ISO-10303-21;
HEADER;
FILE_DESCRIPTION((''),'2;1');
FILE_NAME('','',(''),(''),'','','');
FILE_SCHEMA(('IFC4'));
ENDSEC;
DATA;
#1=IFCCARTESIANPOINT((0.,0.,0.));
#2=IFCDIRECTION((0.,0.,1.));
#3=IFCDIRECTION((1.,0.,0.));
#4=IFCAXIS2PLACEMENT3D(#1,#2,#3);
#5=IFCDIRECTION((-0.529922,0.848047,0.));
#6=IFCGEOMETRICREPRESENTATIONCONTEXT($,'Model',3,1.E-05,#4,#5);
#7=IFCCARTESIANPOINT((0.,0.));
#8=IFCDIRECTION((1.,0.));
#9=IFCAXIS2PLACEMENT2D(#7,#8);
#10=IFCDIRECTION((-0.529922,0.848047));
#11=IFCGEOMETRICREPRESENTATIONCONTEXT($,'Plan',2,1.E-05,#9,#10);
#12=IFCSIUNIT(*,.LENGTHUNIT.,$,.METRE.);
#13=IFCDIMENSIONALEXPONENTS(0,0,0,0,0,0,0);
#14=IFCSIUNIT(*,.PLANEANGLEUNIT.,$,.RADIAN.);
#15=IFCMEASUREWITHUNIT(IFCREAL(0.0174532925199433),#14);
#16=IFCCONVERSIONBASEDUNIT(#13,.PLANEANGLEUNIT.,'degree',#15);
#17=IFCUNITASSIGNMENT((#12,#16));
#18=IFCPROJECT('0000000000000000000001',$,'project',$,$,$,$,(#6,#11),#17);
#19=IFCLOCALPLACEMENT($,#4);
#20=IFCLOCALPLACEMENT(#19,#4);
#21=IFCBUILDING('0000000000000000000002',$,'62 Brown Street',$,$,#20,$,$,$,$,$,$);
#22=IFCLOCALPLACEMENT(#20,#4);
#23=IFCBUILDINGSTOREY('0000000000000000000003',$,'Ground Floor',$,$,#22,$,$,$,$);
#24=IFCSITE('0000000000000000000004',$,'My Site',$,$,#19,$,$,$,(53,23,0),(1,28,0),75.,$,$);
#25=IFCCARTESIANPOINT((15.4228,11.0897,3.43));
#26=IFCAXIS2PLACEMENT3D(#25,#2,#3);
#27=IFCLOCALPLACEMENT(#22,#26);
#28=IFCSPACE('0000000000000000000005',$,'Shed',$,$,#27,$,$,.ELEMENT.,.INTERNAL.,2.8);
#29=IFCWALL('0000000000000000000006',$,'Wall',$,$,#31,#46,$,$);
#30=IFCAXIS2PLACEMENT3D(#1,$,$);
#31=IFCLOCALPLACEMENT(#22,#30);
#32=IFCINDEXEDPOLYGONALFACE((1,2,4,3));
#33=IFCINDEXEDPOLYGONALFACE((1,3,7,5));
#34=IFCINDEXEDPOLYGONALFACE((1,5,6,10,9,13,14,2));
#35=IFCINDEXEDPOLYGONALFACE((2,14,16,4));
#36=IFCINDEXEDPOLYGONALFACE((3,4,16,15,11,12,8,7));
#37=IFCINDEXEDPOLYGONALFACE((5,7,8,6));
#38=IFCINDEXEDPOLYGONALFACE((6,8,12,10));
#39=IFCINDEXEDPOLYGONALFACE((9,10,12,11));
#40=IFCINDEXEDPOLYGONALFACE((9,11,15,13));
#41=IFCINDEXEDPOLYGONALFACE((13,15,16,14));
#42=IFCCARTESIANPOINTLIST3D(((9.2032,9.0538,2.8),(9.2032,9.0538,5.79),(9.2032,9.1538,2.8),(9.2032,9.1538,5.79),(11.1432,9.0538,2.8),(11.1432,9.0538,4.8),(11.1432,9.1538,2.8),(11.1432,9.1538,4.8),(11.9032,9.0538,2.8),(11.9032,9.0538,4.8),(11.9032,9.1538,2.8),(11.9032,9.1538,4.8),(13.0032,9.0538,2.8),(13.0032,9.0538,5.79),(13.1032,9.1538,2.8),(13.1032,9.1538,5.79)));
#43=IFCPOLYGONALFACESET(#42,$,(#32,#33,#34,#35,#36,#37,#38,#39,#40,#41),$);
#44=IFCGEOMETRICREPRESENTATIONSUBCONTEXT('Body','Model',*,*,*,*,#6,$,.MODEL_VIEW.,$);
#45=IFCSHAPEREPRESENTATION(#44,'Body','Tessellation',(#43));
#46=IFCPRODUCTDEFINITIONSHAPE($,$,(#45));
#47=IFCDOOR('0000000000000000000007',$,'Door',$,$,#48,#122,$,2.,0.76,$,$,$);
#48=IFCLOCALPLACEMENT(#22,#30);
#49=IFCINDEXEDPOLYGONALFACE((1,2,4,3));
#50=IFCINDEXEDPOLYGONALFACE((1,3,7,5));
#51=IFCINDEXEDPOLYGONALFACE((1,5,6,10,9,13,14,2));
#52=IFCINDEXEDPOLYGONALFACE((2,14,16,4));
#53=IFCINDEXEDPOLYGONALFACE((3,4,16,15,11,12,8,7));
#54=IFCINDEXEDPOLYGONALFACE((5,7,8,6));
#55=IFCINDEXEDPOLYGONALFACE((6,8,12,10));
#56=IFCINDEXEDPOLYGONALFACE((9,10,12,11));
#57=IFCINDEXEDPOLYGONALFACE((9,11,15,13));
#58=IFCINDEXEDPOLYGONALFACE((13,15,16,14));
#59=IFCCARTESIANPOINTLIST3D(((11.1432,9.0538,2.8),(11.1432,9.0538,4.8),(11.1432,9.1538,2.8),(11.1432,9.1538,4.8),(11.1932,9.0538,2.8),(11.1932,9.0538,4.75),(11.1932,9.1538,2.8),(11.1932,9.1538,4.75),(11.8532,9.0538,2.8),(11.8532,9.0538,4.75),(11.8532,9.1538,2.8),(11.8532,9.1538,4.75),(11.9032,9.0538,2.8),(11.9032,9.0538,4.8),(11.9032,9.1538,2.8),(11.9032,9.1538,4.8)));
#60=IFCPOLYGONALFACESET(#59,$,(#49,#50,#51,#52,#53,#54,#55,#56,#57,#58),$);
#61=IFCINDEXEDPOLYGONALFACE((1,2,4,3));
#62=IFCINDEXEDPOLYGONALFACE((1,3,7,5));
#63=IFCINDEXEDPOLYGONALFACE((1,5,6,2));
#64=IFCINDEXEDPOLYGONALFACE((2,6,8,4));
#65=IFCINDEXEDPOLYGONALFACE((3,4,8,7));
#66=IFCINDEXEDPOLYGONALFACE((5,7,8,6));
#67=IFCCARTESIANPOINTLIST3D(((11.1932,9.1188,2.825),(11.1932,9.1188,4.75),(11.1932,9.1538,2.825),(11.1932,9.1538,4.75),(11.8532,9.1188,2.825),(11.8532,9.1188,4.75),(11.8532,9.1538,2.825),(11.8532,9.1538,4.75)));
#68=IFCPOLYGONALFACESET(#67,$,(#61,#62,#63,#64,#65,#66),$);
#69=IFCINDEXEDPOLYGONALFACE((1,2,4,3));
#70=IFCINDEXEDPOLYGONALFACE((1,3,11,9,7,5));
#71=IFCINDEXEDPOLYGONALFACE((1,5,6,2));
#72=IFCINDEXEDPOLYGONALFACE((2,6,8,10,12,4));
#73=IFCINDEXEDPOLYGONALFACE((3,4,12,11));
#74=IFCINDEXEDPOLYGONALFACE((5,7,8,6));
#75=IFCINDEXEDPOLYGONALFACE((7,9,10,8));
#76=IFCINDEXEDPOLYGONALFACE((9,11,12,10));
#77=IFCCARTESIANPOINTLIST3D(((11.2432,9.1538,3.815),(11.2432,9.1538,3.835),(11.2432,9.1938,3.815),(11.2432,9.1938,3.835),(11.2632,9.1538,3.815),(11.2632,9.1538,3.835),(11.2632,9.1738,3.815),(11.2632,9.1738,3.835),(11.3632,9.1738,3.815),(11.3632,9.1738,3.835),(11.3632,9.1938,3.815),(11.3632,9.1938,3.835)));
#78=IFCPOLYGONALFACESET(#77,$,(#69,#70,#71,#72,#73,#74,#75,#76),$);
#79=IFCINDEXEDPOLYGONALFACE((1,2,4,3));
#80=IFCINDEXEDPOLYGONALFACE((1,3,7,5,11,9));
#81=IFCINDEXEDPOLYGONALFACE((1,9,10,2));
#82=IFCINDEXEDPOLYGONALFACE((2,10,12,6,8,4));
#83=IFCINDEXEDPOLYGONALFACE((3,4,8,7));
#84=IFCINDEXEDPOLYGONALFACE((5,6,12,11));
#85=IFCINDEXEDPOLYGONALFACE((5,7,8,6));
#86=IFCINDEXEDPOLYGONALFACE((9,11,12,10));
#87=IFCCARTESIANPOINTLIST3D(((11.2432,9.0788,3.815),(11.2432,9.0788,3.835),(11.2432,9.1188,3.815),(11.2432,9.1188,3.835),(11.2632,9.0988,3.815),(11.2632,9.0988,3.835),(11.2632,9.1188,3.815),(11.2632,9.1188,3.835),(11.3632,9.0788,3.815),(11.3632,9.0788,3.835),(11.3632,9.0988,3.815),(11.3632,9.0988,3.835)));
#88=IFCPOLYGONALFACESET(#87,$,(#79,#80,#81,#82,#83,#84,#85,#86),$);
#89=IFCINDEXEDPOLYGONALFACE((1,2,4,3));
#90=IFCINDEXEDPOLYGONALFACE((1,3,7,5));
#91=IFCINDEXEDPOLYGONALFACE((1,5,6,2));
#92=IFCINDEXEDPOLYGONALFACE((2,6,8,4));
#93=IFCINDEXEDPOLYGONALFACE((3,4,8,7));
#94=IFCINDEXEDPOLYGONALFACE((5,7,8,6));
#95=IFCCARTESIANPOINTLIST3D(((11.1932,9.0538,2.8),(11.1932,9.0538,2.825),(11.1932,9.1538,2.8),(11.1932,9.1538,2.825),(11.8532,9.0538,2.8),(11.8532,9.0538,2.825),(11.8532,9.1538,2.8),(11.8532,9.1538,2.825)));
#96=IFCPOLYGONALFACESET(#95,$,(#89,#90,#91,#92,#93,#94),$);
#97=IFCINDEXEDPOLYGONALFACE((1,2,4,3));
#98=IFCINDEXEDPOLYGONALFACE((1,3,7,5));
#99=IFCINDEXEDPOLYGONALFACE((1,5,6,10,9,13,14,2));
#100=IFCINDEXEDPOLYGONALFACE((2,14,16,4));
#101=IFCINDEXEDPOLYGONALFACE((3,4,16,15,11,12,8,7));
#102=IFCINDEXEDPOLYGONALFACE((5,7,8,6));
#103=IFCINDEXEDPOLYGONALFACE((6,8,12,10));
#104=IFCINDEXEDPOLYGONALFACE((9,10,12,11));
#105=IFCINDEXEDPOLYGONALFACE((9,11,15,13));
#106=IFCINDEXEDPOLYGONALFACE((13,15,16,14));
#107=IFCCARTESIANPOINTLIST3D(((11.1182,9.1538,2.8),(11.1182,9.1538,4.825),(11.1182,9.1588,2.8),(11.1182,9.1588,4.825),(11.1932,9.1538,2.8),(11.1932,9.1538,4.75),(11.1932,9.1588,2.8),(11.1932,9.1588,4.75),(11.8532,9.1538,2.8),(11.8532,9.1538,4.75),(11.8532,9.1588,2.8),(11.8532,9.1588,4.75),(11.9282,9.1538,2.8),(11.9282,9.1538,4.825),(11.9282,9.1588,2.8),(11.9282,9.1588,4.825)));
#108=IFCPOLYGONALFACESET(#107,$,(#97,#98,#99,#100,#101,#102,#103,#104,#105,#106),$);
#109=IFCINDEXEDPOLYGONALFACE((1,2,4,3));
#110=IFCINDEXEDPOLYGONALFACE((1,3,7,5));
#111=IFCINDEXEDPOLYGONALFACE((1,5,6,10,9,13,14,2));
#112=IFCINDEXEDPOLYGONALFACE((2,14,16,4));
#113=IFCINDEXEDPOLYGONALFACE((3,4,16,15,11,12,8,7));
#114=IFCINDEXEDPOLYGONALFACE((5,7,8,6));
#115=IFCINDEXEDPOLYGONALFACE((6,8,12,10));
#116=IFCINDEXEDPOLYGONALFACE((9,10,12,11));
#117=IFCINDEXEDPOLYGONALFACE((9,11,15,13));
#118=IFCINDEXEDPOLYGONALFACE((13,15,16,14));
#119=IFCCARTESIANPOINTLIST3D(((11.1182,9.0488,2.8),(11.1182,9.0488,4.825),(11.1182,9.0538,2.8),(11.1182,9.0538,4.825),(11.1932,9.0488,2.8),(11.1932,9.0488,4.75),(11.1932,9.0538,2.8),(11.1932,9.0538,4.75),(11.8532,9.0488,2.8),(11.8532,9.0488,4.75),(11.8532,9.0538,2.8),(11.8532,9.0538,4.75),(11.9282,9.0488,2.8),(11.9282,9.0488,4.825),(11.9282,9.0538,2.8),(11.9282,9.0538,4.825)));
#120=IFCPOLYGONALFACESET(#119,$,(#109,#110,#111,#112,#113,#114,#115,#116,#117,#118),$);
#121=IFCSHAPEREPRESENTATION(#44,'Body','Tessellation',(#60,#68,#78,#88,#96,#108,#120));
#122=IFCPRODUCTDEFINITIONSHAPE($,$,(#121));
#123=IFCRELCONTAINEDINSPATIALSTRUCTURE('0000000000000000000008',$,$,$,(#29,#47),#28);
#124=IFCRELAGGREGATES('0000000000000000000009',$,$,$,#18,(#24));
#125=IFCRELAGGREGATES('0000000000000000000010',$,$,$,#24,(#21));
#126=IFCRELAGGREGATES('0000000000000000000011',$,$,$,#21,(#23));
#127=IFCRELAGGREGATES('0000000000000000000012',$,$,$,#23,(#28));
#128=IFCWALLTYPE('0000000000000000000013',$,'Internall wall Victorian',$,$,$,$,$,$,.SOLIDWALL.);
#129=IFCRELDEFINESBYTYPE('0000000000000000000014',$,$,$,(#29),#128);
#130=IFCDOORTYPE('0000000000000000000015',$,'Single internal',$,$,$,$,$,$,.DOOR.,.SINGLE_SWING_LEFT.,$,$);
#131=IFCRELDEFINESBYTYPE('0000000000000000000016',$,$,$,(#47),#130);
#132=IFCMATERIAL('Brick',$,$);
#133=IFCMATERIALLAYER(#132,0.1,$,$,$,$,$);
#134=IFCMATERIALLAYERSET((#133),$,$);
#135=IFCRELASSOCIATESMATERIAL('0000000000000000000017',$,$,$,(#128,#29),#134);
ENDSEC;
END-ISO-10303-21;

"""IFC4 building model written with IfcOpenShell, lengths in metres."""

from ifc_helpers import new_model, entity, si_unit, converted_unit, direction, frame, origin_with_axes, origin_2d_with_axis, place, context, subcontext, project, spatial, line, indexed_curve, outline, extrude, clip, halfspace, shape, source, transform, mapped, material, layer, layer_set, layer_usage, type_object, type_shapes, element, fill, save


model = new_model("IFC4")

# Units and contexts
model_context = context("Model", 3, precision=1e-05, world=origin_with_axes(), true_north=direction((-0.529922, 0.848047, 0.0)))
plan_context = context("Plan", 2, precision=1e-05, world=origin_2d_with_axis(), true_north=direction((-0.529922, 0.848047)))
body_context_1 = subcontext(model_context, "Body", "Model", "MODEL_VIEW")
body_context_2 = subcontext(plan_context, "Body", "Plan", "PLAN_VIEW")
ifc_project = project(units=[si_unit("LENGTHUNIT", "METRE"), converted_unit("PLANEANGLEUNIT", "degree", entity("IfcReal", 0.0174532925199433), si_unit("PLANEANGLEUNIT", "RADIAN"), dimensions=[0, 0, 0, 0, 0, 0, 0])], contexts=[model_context, plan_context])

# Site, building, storey
site_placement = place(None, origin_with_axes())
site = spatial("IfcSite", under=ifc_project, at=site_placement, Name="My Site", RefLatitude=(53, 23, 0), RefLongitude=(1, 28, 0), RefElevation=75.0)
building_placement = place(site_placement, origin_with_axes())
building = spatial("IfcBuilding", under=site, at=building_placement, Name="62 Brown Street")
storey_placement = place(building_placement, origin_with_axes())
storey = spatial("IfcBuildingStorey", under=building, at=storey_placement, Name="Ground Floor")

# Shared definitions
space_placement = place(storey_placement, frame((15.4228, 11.0897, 3.43), z_axis=(0.0, 0.0, 1.0), x_axis=(1.0, 0.0, 0.0)))
space = spatial("IfcSpace", under=storey, at=space_placement, Name="Shed", CompositionType="ELEMENT", PredefinedType="INTERNAL", ElevationWithFlooring=2.8)

# Shared definitions
ifc_material_1 = material(Name="Brick")
ifc_layer_1 = layer(ifc_material_1, 0.1)
ifc_layer_set_1 = layer_set([ifc_layer_1])
wall_type = type_object("IfcWallType", Name="Internall wall Victorian", PredefinedType="SOLIDWALL", material=ifc_layer_set_1)

# Wall, opening, door
ifc_layer_usage_1 = layer_usage(ifc_layer_set_1, "AXIS2", "POSITIVE", 0.0)
wall_1_placement = place(None, frame((13.1032, 9.1538, 2.8), z_axis=(0.0, 0.0, 1.0), x_axis=(-1.0, 0.0, 0.0)))
wall_1 = element("IfcWall", 1, at=wall_1_placement, inside=space, type_object=wall_type, material=ifc_layer_usage_1, Name="Wall", context=body_context_1, shape_type="Clipping", body=[
    clip(extrude(outline(indexed_curve([(0.0, 0.0), (0.0, 0.1), (3.9, 0.1), (3.9, 0.0), (0.0, 0.0)], self_intersect=False)), origin_with_axes(), (0.0, 0.0, 1.0), 2.99), halfspace(frame((0.0, 0.0, -2.8), z_axis=(-0.707104, 0.70711, 0.0), x_axis=(0.70711, 0.707104, 0.0)), False)),
])
shared_shape_1 = source(origin_with_axes(), body_context_1, "Body", "SweptSolid", [
    extrude(outline(indexed_curve([(0.0, 0.0), (0.76, 0.0), (0.76, 2.0), (0.0, 2.0)], segments=[line(1, 2, 3, 4, 1)])), frame((0.0, -0.6, 0.0), z_axis=(0.0, -1.0, 0.0), x_axis=(1.0, 0.0, 0.0)), (0.0, 0.0, -1.0), 1.2),
])
opening_placement = place(wall_1_placement, frame((1.2, 0.0, 0.0), z_axis=(0.0, 0.0, 1.0), x_axis=(1.0, 0.0, 0.0)))
opening = element("IfcOpeningElement", 2, at=opening_placement, cuts=wall_1, PredefinedType="OPENING", context=body_context_1, shape_type="MappedRepresentation", body=[
    mapped(shared_shape_1, transform((0.0, 0.0, 0.0), x_axis=(1.0, 0.0, 0.0), y_axis=(0.0, 1.0, 0.0), z_axis=(0.0, 0.0, 1.0), scale=1.0)),
])
door_type = type_object("IfcDoorType", Name="Single internal", OperationType="SINGLE_SWING_LEFT", PredefinedType="DOOR")
shared_shape_2 = source(origin_with_axes(), body_context_1, "Body", "SweptSolid", [
    extrude(outline(indexed_curve([(0.0, 0.0), (0.0, 2.0), (0.76, 2.0), (0.76, 0.0), (0.71, 0.0), (0.71, 1.95), (0.05, 1.95), (0.05, 0.0)], segments=[line(1, 2, 3, 4, 5, 6, 7, 8, 1)])), frame((0.0, 0.0, 0.0), z_axis=(0.0, -1.0, 0.0), x_axis=(1.0, 0.0, 0.0)), (0.0, 0.0, -1.0), 0.1),
    extrude(outline(indexed_curve([(0.0, 0.0), (0.66, 0.0), (0.66, 0.035), (0.0, 0.035)], segments=[line(1, 2, 3, 4, 1)])), frame((0.05, 0.0, 0.025), z_axis=(0.0, 0.0, 1.0), x_axis=(1.0, 0.0, 0.0)), (0.0, 0.0, 1.0), 1.925),
    extrude(outline(indexed_curve([(0.0, 0.0), (0.0, -0.04), (-0.12, -0.04), (-0.12, -0.02), (-0.02, -0.02), (-0.02, 0.0)], segments=[line(1, 2, 3, 4, 5, 6, 1)])), frame((0.66, 0.0, 1.015), z_axis=(0.0, 0.0, 1.0), x_axis=(1.0, 0.0, 0.0)), (0.0, 0.0, 1.0), 0.02),
    extrude(outline(indexed_curve([(0.0, 0.0), (0.0, 0.04), (-0.12, 0.04), (-0.12, 0.02), (-0.02, 0.02), (-0.02, 0.0)], segments=[line(1, 2, 3, 4, 5, 6, 1)])), frame((0.66, 0.035, 1.015), z_axis=(0.0, 0.0, 1.0), x_axis=(1.0, 0.0, 0.0)), (0.0, 0.0, 1.0), 0.02),
    extrude(outline(indexed_curve([(0.0, 0.0), (0.66, 0.0), (0.66, 0.1), (0.0, 0.1)], segments=[line(1, 2, 3, 4, 1)])), frame((0.05, 0.0, 0.0), z_axis=(0.0, 0.0, 1.0), x_axis=(1.0, 0.0, 0.0)), (0.0, 0.0, 1.0), 0.025),
    extrude(outline(indexed_curve([(0.0, 0.0), (0.0, 2.025), (0.81, 2.025), (0.81, 0.0), (0.735, 0.0), (0.735, 1.95), (0.075, 1.95), (0.075, 0.0)], segments=[line(1, 2, 3, 4, 5, 6, 7, 8, 1)])), frame((-0.025, -0.005, 0.0), z_axis=(0.0, -1.0, 0.0), x_axis=(1.0, 0.0, 0.0)), (0.0, 0.0, -1.0), 0.005),
    extrude(outline(indexed_curve([(0.0, 0.0), (0.0, 2.025), (0.81, 2.025), (0.81, 0.0), (0.735, 0.0), (0.735, 1.95), (0.075, 1.95), (0.075, 0.0)], segments=[line(1, 2, 3, 4, 5, 6, 7, 8, 1)])), frame((-0.025, 0.1, 0.0), z_axis=(0.0, -1.0, 0.0), x_axis=(1.0, 0.0, 0.0)), (0.0, 0.0, -1.0), 0.005),
])
shared_shape_3 = source(origin_with_axes(), body_context_2, "Body", "Curve2D", [
    entity("IfcIndexedPolyCurve", entity("IfcCartesianPointList2D", [[0.0, 0.0], [0.05, 0.0], [0.05, 0.1], [0.0, 0.1]]), [entity("IfcLineIndex", [1, 2, 3, 4, 1])]),
    entity("IfcIndexedPolyCurve", entity("IfcCartesianPointList2D", [[0.76, 0.0], [0.71, 0.0], [0.71, 0.1], [0.76, 0.1]]), [entity("IfcLineIndex", [1, 2, 3, 4, 1])]),
    entity("IfcTrimmedCurve", entity("IfcEllipse", entity("IfcAxis2Placement2D", entity("IfcCartesianPoint", [0.085, 0.1]), entity("IfcDirection", [1.0, 0.0])), 0.625, 0.66), [entity("IfcCartesianPoint", [0.71, 0.1])], [entity("IfcCartesianPoint", [0.085, 0.76])], True, "CARTESIAN"),
    entity("IfcIndexedPolyCurve", entity("IfcCartesianPointList2D", [[0.05, 0.1], [0.085, 0.1], [0.085, 0.76], [0.05, 0.76]]), [entity("IfcLineIndex", [1, 2, 3, 4, 1])]),
])
type_shapes(door_type, [shared_shape_2, shared_shape_3])
door_placement = place(opening_placement, frame((0.0, 0.0, 0.0), z_axis=(0.0, 0.0, 1.0), x_axis=(1.0, 0.0, 0.0)))
door = element("IfcDoor", 3, at=door_placement, inside=space, type_object=door_type, Name="Door", OverallHeight=2.0, OverallWidth=0.76, shapes=[
    shape(body_context_1, "Body", "MappedRepresentation", [mapped(shared_shape_2, transform((0.0, 0.0, 0.0), x_axis=(1.0, 0.0, 0.0), y_axis=(0.0, 1.0, 0.0), z_axis=(0.0, 0.0, 1.0), scale=1.0))]),
    shape(body_context_2, "Body", "MappedRepresentation", [mapped(shared_shape_3, transform((0.0, 0.0, 0.0), x_axis=(1.0, 0.0, 0.0), y_axis=(0.0, 1.0, 0.0), z_axis=(0.0, 0.0, 1.0), scale=1.0))]),
])
fill(opening, door)

save(model, "model.ifc")
